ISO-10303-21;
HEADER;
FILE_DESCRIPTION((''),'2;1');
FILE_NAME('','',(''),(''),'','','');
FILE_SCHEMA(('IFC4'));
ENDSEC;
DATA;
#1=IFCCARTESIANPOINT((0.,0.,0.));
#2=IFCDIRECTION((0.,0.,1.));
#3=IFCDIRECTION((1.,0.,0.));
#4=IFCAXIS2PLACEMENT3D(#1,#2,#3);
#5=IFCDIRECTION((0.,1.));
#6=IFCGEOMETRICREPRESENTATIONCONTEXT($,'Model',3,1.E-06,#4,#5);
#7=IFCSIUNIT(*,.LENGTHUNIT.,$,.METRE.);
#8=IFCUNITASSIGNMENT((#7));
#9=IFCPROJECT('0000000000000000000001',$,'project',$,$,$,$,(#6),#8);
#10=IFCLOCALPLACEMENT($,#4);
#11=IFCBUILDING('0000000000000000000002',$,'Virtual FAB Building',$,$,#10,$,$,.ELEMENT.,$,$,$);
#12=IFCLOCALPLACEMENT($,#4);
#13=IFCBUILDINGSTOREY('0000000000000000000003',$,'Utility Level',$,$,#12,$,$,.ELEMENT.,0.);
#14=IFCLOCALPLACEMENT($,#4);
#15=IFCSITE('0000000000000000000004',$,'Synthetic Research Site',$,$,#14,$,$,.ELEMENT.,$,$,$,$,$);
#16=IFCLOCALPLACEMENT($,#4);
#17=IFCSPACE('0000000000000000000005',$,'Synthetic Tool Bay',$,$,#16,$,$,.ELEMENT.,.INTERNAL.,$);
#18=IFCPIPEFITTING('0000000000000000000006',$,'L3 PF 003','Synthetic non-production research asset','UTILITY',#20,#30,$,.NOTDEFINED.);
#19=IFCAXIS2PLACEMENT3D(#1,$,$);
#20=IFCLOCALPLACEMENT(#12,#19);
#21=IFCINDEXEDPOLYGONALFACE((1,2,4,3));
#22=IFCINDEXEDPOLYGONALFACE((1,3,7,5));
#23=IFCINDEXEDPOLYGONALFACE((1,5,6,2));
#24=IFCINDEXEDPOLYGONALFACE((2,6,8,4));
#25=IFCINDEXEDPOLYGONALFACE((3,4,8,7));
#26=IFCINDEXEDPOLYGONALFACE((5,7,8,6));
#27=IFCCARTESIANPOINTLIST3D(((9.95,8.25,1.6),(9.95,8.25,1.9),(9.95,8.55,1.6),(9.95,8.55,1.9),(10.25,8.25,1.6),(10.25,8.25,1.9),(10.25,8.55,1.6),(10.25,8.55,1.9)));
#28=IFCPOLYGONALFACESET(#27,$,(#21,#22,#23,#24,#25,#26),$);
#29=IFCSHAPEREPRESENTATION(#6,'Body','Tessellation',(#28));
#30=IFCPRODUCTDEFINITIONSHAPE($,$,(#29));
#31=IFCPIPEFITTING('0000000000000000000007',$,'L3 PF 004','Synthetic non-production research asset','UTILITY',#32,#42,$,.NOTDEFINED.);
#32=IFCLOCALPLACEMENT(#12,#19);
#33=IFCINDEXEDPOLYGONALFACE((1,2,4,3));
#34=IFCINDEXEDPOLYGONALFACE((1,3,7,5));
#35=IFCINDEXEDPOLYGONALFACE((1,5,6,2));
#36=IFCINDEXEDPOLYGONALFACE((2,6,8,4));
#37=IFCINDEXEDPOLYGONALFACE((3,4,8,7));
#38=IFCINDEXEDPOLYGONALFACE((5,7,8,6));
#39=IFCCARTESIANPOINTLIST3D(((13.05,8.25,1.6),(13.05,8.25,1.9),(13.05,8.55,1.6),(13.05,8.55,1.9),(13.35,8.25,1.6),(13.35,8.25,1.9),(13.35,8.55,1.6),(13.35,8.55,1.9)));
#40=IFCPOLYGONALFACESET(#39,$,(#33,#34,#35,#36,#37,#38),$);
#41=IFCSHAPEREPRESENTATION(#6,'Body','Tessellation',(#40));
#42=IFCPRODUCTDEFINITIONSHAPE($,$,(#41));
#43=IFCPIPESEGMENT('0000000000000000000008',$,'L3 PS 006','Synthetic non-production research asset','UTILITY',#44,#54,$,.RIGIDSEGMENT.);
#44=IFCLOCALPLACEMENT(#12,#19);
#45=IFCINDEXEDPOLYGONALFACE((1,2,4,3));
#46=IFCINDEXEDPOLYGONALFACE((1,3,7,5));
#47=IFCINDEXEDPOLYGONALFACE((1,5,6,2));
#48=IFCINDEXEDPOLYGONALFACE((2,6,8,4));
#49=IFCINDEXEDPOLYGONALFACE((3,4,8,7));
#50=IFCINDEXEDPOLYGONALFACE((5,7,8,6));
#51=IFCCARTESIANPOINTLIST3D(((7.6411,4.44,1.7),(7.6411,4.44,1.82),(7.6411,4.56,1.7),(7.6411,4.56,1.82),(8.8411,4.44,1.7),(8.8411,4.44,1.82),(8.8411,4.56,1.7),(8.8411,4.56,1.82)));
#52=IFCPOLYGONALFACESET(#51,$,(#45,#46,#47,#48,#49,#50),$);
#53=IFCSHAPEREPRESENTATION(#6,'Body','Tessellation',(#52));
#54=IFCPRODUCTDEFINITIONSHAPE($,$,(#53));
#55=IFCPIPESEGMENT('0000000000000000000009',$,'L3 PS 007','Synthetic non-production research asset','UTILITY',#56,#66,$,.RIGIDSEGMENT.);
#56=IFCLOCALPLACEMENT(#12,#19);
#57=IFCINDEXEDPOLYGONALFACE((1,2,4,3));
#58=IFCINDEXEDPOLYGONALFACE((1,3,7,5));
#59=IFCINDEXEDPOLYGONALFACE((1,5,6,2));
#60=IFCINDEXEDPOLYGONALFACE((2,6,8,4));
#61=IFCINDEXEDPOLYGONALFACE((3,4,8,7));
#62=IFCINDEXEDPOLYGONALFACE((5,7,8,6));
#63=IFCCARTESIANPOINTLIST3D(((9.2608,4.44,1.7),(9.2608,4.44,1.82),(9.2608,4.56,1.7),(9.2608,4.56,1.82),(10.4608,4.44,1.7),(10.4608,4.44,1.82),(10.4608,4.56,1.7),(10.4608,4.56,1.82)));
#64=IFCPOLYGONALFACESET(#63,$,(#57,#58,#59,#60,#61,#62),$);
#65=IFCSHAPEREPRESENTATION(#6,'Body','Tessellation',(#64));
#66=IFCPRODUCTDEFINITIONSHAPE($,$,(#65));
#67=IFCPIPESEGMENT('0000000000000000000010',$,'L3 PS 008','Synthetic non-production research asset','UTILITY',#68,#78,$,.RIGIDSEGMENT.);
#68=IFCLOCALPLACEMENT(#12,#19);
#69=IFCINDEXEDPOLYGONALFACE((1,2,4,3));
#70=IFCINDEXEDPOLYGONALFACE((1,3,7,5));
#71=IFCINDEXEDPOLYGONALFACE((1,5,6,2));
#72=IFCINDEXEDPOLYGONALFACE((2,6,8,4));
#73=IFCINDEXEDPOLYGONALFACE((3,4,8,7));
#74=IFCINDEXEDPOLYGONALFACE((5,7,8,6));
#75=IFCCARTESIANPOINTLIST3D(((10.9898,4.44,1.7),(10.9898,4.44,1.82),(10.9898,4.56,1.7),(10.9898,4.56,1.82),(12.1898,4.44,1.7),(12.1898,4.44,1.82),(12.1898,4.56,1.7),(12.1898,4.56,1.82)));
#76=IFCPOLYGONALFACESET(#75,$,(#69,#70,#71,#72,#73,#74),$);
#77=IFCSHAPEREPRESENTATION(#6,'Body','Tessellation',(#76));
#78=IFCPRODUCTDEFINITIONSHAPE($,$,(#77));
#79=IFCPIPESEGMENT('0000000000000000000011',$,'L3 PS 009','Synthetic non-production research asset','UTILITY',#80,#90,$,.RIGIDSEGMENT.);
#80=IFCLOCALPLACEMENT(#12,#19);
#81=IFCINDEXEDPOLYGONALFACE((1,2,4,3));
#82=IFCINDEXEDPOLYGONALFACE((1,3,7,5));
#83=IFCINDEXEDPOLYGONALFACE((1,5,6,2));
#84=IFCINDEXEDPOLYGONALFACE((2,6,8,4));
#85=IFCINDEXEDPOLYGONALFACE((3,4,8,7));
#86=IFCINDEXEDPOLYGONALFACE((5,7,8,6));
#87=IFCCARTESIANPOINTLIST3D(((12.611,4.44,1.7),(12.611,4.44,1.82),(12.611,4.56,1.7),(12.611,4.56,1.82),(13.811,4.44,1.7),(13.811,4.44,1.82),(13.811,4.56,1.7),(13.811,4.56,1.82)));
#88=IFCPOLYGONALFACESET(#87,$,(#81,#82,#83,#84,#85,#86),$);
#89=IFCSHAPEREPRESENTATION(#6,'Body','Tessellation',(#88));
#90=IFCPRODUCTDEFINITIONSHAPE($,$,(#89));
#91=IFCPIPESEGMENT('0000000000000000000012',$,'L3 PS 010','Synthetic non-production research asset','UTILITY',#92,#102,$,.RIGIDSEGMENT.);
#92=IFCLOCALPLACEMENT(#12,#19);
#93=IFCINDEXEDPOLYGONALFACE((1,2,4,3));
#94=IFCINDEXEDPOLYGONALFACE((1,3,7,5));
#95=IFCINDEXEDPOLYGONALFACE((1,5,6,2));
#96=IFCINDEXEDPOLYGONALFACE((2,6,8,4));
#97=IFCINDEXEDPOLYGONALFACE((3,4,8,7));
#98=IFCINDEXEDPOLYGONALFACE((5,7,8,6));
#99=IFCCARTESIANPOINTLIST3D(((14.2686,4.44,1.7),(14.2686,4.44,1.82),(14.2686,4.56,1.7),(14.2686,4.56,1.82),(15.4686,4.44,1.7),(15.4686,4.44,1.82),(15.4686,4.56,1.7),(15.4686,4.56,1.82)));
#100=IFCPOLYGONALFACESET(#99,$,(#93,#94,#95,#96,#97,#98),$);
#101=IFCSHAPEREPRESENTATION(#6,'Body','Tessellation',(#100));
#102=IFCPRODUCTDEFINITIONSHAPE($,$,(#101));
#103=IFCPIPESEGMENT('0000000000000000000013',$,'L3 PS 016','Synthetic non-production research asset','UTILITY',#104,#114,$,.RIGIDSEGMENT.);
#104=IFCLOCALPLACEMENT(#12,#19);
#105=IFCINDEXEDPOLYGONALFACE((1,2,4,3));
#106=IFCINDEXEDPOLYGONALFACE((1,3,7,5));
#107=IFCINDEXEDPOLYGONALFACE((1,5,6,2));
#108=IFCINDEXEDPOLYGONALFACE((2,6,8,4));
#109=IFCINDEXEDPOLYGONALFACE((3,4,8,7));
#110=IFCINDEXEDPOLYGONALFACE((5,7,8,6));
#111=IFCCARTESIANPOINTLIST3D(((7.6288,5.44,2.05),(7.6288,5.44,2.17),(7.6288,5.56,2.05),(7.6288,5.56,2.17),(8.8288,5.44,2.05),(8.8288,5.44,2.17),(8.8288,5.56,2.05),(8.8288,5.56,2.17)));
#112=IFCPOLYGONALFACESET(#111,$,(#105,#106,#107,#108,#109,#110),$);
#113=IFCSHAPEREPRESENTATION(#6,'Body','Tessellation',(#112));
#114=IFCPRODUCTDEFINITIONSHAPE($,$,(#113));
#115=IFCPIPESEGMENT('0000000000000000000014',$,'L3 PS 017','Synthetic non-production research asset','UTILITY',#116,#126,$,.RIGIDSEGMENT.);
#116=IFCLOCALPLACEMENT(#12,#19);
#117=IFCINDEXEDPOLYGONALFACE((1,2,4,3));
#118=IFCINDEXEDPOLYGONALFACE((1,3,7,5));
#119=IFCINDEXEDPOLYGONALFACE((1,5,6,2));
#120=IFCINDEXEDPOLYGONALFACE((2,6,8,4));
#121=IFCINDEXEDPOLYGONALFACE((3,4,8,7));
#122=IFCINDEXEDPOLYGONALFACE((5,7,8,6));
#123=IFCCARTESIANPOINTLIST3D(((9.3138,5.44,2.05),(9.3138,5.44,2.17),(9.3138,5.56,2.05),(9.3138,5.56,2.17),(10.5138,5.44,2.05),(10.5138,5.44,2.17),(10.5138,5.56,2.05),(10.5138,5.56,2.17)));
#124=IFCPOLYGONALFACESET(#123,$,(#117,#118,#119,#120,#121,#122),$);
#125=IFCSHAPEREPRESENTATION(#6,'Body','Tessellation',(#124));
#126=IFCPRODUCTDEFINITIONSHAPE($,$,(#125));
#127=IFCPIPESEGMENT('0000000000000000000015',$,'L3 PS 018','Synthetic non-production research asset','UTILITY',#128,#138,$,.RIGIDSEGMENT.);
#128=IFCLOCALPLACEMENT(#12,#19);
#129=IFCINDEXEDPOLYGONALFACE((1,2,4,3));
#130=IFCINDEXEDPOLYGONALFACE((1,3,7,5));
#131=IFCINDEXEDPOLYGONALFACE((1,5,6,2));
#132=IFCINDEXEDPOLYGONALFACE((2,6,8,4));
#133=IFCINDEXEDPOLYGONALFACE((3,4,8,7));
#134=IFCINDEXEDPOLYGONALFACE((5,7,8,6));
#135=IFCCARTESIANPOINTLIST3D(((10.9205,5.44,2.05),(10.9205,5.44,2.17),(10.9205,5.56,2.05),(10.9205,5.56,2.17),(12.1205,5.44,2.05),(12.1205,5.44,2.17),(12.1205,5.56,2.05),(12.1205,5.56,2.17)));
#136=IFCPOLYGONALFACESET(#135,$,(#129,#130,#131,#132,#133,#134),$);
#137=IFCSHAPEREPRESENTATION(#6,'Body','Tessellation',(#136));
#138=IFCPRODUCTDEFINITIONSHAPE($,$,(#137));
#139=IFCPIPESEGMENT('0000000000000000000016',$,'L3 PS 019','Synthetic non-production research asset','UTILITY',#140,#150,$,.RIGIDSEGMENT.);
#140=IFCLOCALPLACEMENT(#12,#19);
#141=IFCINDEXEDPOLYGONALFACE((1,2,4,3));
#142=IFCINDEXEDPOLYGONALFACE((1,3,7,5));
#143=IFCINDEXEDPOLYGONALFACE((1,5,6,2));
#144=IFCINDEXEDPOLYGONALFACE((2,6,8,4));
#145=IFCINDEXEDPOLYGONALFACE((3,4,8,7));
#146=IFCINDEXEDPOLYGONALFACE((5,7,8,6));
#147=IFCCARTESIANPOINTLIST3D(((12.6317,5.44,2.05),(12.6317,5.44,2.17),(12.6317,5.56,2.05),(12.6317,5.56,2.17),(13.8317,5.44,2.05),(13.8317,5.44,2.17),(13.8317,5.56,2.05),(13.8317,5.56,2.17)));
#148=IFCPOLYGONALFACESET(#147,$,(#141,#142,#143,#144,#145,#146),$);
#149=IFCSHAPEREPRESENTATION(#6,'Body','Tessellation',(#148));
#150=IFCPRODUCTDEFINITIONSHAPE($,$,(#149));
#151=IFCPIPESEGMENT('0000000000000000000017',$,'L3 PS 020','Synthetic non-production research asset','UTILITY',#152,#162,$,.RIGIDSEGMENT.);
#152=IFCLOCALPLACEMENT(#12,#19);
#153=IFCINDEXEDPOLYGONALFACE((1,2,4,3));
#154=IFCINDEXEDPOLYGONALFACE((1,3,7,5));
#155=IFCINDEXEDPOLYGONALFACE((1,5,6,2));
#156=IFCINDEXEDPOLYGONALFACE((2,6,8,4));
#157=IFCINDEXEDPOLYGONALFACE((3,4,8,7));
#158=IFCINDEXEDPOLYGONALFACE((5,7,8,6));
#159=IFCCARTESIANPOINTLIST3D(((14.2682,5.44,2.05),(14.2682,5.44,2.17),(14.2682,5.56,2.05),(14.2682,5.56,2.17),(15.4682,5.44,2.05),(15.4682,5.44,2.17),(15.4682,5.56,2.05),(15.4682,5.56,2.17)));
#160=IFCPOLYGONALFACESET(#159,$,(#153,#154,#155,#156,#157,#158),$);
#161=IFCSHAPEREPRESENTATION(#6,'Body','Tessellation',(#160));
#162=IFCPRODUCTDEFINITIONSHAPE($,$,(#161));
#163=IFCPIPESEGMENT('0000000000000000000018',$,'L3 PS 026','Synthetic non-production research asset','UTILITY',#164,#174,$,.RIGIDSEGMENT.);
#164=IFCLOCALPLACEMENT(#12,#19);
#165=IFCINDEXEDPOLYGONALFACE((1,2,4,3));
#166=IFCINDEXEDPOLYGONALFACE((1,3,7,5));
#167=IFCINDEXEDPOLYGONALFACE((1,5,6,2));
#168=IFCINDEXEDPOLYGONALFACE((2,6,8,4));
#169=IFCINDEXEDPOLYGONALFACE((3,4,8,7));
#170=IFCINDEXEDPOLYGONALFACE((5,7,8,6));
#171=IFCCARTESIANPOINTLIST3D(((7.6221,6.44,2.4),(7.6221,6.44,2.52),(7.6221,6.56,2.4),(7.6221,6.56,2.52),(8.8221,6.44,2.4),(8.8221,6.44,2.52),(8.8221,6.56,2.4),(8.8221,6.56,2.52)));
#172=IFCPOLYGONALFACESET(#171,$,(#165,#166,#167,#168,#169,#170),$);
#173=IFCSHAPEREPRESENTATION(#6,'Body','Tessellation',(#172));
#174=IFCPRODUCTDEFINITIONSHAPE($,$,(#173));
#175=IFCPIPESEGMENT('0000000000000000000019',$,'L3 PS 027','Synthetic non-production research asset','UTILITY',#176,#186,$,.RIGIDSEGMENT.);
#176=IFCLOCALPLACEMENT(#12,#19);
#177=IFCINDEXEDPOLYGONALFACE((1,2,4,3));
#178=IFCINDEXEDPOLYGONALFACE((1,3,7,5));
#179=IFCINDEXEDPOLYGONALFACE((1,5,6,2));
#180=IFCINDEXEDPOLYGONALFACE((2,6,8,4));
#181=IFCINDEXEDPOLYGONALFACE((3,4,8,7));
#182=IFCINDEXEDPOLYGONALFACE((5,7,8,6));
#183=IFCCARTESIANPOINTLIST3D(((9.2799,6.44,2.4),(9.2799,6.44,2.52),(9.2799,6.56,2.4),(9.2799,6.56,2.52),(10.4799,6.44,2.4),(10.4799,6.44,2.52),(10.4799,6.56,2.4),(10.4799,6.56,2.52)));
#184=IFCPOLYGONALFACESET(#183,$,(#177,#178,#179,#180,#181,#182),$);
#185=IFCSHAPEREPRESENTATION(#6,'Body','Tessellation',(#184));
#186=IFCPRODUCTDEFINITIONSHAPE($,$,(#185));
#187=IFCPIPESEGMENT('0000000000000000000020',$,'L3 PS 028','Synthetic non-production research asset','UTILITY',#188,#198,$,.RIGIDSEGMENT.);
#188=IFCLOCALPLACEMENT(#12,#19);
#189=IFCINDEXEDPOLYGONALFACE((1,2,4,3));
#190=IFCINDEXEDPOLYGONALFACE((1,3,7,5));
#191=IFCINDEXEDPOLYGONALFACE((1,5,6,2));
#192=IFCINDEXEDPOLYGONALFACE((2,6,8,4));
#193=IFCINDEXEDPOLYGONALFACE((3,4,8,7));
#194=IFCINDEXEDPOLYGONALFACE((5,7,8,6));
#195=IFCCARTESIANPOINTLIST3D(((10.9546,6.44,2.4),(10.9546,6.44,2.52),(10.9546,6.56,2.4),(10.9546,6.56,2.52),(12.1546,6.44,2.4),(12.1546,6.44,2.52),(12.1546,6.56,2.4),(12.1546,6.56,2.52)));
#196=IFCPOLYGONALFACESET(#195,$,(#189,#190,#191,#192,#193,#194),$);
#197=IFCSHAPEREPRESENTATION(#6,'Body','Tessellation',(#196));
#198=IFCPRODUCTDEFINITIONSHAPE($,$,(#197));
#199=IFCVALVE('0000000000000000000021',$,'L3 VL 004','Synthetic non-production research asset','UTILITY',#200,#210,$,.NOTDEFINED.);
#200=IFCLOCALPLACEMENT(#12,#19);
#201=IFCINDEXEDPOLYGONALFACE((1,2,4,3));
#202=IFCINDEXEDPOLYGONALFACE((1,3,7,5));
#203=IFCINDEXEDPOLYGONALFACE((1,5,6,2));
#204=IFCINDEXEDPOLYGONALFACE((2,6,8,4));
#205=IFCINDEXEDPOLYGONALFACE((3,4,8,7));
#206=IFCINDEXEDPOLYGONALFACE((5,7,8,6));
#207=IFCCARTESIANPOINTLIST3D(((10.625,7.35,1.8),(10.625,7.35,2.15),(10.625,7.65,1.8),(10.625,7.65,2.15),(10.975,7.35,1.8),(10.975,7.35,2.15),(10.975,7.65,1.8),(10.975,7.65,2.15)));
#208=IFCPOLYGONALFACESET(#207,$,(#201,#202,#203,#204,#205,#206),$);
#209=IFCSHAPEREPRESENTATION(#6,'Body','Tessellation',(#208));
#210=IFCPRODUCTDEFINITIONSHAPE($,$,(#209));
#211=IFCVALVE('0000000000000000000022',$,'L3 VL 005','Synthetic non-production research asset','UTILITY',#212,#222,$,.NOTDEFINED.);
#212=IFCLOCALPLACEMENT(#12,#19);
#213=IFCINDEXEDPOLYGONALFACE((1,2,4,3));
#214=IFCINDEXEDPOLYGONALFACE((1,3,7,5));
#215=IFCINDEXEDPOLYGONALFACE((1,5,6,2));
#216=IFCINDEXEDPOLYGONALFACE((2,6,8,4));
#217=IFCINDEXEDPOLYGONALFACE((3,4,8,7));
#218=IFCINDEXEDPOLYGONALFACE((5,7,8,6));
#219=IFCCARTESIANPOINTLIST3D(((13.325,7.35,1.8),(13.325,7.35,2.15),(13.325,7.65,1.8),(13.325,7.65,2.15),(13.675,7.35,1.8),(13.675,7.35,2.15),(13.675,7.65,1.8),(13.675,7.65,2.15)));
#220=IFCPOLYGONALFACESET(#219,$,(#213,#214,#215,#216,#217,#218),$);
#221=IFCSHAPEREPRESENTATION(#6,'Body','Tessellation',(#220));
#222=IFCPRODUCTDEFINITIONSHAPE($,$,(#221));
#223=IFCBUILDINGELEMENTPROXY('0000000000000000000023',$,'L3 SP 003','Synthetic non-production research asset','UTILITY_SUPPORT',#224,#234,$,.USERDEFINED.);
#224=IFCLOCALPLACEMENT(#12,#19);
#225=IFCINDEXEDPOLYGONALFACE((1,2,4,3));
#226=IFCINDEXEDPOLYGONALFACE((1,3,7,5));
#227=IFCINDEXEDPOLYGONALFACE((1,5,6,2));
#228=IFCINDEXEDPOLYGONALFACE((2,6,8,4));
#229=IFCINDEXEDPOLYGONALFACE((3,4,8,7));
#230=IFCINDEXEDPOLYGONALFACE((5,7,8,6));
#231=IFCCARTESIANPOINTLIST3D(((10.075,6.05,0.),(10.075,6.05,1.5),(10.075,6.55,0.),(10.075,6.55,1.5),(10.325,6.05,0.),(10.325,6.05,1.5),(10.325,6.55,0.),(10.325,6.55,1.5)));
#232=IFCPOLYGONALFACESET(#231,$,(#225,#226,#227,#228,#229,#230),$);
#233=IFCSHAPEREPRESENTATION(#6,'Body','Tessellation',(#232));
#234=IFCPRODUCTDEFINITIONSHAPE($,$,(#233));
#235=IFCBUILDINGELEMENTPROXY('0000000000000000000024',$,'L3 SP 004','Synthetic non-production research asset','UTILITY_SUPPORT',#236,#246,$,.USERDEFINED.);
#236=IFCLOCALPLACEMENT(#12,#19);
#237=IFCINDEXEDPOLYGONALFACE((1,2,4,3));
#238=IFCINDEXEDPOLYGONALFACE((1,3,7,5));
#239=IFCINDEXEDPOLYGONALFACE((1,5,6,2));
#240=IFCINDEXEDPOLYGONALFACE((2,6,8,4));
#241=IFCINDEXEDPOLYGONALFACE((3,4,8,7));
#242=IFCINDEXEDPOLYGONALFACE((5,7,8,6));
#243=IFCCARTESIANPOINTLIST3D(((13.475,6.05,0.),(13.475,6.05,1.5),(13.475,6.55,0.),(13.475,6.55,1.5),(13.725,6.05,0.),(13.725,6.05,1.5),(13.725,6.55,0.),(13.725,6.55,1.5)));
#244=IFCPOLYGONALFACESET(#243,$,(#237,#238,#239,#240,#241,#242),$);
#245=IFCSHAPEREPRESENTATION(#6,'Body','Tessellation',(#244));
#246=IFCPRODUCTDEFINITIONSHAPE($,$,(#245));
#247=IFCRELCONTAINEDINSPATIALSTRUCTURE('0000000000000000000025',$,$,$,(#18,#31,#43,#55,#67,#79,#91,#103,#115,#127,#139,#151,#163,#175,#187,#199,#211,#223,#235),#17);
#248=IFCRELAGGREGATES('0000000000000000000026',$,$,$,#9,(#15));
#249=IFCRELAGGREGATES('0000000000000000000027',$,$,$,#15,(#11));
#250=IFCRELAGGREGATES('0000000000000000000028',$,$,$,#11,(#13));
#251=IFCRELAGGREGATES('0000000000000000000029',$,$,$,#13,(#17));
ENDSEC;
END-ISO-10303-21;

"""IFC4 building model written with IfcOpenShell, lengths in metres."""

from ifc_helpers import new_model, si_unit, direction, frame, origin_with_axes, origin_2d_with_axis, place, context, project, spatial, rectangle, extrude, element, save


model = new_model("IFC4")

# Units and contexts
model_context = context("Model", 3, precision=1e-06, world=origin_with_axes(), true_north=direction((0.0, 1.0)))
ifc_project = project(units=[si_unit("LENGTHUNIT", "METRE")], contexts=[model_context])

# Site, building, storey, space
site_placement = place(None, origin_with_axes())
site = spatial("IfcSite", under=ifc_project, at=site_placement, Name="Synthetic Research Site", CompositionType="ELEMENT")
building_placement = place(None, origin_with_axes())
building = spatial("IfcBuilding", under=site, at=building_placement, Name="Virtual FAB Building", CompositionType="ELEMENT")
storey_placement = place(None, origin_with_axes())
storey = spatial("IfcBuildingStorey", under=building, at=storey_placement, Name="Utility Level", CompositionType="ELEMENT", Elevation=0.0)
space_placement = place(None, origin_with_axes())
space = spatial("IfcSpace", under=storey, at=space_placement, Name="Synthetic Tool Bay", CompositionType="ELEMENT", PredefinedType="INTERNAL")

# Pipe fittings
for number, where, z_axis, x_axis, name in (
    (1, (10.1, 8.4, 1.6), (0.0, 0.0, 1.0), (1.0, 0.0, 0.0), "L3 PF 003"),
    (2, (13.2, 8.4, 1.6), (0.0, 0.0, 1.0), (1.0, 0.0, 0.0), "L3 PF 004"),
):
    element("IfcPipeFitting", number, at=place(None, frame(where, z_axis=z_axis, x_axis=x_axis)), inside=space, Name=name, Description="Synthetic non-production research asset", ObjectType="UTILITY", PredefinedType="NOTDEFINED", context=model_context, shape_type="SweptSolid", body=[
        extrude(rectangle(XDim=0.3, YDim=0.3, at=origin_2d_with_axis()), origin_with_axes(), (0.0, 0.0, 1.0), 0.3),
    ])

# Pipe segments
for number, where, z_axis, x_axis, name in (
    (3, (8.2411, 4.5, 1.7), (0.0, 0.0, 1.0), (1.0, 0.0, 0.0), "L3 PS 006"),
    (4, (9.8608, 4.5, 1.7), (0.0, 0.0, 1.0), (1.0, 0.0, 0.0), "L3 PS 007"),
    (5, (11.5898, 4.5, 1.7), (0.0, 0.0, 1.0), (1.0, 0.0, 0.0), "L3 PS 008"),
    (6, (13.211, 4.5, 1.7), (0.0, 0.0, 1.0), (1.0, 0.0, 0.0), "L3 PS 009"),
    (7, (14.8686, 4.5, 1.7), (0.0, 0.0, 1.0), (1.0, 0.0, 0.0), "L3 PS 010"),
    (8, (8.2288, 5.5, 2.05), (0.0, 0.0, 1.0), (1.0, 0.0, 0.0), "L3 PS 016"),
    (9, (9.9138, 5.5, 2.05), (0.0, 0.0, 1.0), (1.0, 0.0, 0.0), "L3 PS 017"),
    (10, (11.5205, 5.5, 2.05), (0.0, 0.0, 1.0), (1.0, 0.0, 0.0), "L3 PS 018"),
    (11, (13.2317, 5.5, 2.05), (0.0, 0.0, 1.0), (1.0, 0.0, 0.0), "L3 PS 019"),
    (12, (14.8682, 5.5, 2.05), (0.0, 0.0, 1.0), (1.0, 0.0, 0.0), "L3 PS 020"),
    (13, (8.2221, 6.5, 2.4), (0.0, 0.0, 1.0), (1.0, 0.0, 0.0), "L3 PS 026"),
    (14, (9.8799, 6.5, 2.4), (0.0, 0.0, 1.0), (1.0, 0.0, 0.0), "L3 PS 027"),
    (15, (11.5546, 6.5, 2.4), (0.0, 0.0, 1.0), (1.0, 0.0, 0.0), "L3 PS 028"),
):
    element("IfcPipeSegment", number, at=place(None, frame(where, z_axis=z_axis, x_axis=x_axis)), inside=space, Name=name, Description="Synthetic non-production research asset", ObjectType="UTILITY", PredefinedType="RIGIDSEGMENT", context=model_context, shape_type="SweptSolid", body=[
        extrude(rectangle(XDim=1.2, YDim=0.12, at=origin_2d_with_axis()), origin_with_axes(), (0.0, 0.0, 1.0), 0.12),
    ])

# Valves
for number, where, z_axis, x_axis, name in (
    (16, (10.8, 7.5, 1.8), (0.0, 0.0, 1.0), (1.0, 0.0, 0.0), "L3 VL 004"),
    (17, (13.5, 7.5, 1.8), (0.0, 0.0, 1.0), (1.0, 0.0, 0.0), "L3 VL 005"),
):
    element("IfcValve", number, at=place(None, frame(where, z_axis=z_axis, x_axis=x_axis)), inside=space, Name=name, Description="Synthetic non-production research asset", ObjectType="UTILITY", PredefinedType="NOTDEFINED", context=model_context, shape_type="SweptSolid", body=[
        extrude(rectangle(XDim=0.35, YDim=0.3, at=origin_2d_with_axis()), origin_with_axes(), (0.0, 0.0, 1.0), 0.35),
    ])

# Building element proxies
for number, where, z_axis, x_axis, name in (
    (18, (10.2, 6.3, 0.0), (0.0, 0.0, 1.0), (1.0, 0.0, 0.0), "L3 SP 003"),
    (19, (13.6, 6.3, 0.0), (0.0, 0.0, 1.0), (1.0, 0.0, 0.0), "L3 SP 004"),
):
    element("IfcBuildingElementProxy", number, at=place(None, frame(where, z_axis=z_axis, x_axis=x_axis)), inside=space, Name=name, Description="Synthetic non-production research asset", ObjectType="UTILITY_SUPPORT", PredefinedType="USERDEFINED", context=model_context, shape_type="SweptSolid", body=[
        extrude(rectangle(XDim=0.25, YDim=0.5, at=origin_2d_with_axis()), origin_with_axes(), (0.0, 0.0, 1.0), 1.5),
    ])

save(model, "model.ifc")
